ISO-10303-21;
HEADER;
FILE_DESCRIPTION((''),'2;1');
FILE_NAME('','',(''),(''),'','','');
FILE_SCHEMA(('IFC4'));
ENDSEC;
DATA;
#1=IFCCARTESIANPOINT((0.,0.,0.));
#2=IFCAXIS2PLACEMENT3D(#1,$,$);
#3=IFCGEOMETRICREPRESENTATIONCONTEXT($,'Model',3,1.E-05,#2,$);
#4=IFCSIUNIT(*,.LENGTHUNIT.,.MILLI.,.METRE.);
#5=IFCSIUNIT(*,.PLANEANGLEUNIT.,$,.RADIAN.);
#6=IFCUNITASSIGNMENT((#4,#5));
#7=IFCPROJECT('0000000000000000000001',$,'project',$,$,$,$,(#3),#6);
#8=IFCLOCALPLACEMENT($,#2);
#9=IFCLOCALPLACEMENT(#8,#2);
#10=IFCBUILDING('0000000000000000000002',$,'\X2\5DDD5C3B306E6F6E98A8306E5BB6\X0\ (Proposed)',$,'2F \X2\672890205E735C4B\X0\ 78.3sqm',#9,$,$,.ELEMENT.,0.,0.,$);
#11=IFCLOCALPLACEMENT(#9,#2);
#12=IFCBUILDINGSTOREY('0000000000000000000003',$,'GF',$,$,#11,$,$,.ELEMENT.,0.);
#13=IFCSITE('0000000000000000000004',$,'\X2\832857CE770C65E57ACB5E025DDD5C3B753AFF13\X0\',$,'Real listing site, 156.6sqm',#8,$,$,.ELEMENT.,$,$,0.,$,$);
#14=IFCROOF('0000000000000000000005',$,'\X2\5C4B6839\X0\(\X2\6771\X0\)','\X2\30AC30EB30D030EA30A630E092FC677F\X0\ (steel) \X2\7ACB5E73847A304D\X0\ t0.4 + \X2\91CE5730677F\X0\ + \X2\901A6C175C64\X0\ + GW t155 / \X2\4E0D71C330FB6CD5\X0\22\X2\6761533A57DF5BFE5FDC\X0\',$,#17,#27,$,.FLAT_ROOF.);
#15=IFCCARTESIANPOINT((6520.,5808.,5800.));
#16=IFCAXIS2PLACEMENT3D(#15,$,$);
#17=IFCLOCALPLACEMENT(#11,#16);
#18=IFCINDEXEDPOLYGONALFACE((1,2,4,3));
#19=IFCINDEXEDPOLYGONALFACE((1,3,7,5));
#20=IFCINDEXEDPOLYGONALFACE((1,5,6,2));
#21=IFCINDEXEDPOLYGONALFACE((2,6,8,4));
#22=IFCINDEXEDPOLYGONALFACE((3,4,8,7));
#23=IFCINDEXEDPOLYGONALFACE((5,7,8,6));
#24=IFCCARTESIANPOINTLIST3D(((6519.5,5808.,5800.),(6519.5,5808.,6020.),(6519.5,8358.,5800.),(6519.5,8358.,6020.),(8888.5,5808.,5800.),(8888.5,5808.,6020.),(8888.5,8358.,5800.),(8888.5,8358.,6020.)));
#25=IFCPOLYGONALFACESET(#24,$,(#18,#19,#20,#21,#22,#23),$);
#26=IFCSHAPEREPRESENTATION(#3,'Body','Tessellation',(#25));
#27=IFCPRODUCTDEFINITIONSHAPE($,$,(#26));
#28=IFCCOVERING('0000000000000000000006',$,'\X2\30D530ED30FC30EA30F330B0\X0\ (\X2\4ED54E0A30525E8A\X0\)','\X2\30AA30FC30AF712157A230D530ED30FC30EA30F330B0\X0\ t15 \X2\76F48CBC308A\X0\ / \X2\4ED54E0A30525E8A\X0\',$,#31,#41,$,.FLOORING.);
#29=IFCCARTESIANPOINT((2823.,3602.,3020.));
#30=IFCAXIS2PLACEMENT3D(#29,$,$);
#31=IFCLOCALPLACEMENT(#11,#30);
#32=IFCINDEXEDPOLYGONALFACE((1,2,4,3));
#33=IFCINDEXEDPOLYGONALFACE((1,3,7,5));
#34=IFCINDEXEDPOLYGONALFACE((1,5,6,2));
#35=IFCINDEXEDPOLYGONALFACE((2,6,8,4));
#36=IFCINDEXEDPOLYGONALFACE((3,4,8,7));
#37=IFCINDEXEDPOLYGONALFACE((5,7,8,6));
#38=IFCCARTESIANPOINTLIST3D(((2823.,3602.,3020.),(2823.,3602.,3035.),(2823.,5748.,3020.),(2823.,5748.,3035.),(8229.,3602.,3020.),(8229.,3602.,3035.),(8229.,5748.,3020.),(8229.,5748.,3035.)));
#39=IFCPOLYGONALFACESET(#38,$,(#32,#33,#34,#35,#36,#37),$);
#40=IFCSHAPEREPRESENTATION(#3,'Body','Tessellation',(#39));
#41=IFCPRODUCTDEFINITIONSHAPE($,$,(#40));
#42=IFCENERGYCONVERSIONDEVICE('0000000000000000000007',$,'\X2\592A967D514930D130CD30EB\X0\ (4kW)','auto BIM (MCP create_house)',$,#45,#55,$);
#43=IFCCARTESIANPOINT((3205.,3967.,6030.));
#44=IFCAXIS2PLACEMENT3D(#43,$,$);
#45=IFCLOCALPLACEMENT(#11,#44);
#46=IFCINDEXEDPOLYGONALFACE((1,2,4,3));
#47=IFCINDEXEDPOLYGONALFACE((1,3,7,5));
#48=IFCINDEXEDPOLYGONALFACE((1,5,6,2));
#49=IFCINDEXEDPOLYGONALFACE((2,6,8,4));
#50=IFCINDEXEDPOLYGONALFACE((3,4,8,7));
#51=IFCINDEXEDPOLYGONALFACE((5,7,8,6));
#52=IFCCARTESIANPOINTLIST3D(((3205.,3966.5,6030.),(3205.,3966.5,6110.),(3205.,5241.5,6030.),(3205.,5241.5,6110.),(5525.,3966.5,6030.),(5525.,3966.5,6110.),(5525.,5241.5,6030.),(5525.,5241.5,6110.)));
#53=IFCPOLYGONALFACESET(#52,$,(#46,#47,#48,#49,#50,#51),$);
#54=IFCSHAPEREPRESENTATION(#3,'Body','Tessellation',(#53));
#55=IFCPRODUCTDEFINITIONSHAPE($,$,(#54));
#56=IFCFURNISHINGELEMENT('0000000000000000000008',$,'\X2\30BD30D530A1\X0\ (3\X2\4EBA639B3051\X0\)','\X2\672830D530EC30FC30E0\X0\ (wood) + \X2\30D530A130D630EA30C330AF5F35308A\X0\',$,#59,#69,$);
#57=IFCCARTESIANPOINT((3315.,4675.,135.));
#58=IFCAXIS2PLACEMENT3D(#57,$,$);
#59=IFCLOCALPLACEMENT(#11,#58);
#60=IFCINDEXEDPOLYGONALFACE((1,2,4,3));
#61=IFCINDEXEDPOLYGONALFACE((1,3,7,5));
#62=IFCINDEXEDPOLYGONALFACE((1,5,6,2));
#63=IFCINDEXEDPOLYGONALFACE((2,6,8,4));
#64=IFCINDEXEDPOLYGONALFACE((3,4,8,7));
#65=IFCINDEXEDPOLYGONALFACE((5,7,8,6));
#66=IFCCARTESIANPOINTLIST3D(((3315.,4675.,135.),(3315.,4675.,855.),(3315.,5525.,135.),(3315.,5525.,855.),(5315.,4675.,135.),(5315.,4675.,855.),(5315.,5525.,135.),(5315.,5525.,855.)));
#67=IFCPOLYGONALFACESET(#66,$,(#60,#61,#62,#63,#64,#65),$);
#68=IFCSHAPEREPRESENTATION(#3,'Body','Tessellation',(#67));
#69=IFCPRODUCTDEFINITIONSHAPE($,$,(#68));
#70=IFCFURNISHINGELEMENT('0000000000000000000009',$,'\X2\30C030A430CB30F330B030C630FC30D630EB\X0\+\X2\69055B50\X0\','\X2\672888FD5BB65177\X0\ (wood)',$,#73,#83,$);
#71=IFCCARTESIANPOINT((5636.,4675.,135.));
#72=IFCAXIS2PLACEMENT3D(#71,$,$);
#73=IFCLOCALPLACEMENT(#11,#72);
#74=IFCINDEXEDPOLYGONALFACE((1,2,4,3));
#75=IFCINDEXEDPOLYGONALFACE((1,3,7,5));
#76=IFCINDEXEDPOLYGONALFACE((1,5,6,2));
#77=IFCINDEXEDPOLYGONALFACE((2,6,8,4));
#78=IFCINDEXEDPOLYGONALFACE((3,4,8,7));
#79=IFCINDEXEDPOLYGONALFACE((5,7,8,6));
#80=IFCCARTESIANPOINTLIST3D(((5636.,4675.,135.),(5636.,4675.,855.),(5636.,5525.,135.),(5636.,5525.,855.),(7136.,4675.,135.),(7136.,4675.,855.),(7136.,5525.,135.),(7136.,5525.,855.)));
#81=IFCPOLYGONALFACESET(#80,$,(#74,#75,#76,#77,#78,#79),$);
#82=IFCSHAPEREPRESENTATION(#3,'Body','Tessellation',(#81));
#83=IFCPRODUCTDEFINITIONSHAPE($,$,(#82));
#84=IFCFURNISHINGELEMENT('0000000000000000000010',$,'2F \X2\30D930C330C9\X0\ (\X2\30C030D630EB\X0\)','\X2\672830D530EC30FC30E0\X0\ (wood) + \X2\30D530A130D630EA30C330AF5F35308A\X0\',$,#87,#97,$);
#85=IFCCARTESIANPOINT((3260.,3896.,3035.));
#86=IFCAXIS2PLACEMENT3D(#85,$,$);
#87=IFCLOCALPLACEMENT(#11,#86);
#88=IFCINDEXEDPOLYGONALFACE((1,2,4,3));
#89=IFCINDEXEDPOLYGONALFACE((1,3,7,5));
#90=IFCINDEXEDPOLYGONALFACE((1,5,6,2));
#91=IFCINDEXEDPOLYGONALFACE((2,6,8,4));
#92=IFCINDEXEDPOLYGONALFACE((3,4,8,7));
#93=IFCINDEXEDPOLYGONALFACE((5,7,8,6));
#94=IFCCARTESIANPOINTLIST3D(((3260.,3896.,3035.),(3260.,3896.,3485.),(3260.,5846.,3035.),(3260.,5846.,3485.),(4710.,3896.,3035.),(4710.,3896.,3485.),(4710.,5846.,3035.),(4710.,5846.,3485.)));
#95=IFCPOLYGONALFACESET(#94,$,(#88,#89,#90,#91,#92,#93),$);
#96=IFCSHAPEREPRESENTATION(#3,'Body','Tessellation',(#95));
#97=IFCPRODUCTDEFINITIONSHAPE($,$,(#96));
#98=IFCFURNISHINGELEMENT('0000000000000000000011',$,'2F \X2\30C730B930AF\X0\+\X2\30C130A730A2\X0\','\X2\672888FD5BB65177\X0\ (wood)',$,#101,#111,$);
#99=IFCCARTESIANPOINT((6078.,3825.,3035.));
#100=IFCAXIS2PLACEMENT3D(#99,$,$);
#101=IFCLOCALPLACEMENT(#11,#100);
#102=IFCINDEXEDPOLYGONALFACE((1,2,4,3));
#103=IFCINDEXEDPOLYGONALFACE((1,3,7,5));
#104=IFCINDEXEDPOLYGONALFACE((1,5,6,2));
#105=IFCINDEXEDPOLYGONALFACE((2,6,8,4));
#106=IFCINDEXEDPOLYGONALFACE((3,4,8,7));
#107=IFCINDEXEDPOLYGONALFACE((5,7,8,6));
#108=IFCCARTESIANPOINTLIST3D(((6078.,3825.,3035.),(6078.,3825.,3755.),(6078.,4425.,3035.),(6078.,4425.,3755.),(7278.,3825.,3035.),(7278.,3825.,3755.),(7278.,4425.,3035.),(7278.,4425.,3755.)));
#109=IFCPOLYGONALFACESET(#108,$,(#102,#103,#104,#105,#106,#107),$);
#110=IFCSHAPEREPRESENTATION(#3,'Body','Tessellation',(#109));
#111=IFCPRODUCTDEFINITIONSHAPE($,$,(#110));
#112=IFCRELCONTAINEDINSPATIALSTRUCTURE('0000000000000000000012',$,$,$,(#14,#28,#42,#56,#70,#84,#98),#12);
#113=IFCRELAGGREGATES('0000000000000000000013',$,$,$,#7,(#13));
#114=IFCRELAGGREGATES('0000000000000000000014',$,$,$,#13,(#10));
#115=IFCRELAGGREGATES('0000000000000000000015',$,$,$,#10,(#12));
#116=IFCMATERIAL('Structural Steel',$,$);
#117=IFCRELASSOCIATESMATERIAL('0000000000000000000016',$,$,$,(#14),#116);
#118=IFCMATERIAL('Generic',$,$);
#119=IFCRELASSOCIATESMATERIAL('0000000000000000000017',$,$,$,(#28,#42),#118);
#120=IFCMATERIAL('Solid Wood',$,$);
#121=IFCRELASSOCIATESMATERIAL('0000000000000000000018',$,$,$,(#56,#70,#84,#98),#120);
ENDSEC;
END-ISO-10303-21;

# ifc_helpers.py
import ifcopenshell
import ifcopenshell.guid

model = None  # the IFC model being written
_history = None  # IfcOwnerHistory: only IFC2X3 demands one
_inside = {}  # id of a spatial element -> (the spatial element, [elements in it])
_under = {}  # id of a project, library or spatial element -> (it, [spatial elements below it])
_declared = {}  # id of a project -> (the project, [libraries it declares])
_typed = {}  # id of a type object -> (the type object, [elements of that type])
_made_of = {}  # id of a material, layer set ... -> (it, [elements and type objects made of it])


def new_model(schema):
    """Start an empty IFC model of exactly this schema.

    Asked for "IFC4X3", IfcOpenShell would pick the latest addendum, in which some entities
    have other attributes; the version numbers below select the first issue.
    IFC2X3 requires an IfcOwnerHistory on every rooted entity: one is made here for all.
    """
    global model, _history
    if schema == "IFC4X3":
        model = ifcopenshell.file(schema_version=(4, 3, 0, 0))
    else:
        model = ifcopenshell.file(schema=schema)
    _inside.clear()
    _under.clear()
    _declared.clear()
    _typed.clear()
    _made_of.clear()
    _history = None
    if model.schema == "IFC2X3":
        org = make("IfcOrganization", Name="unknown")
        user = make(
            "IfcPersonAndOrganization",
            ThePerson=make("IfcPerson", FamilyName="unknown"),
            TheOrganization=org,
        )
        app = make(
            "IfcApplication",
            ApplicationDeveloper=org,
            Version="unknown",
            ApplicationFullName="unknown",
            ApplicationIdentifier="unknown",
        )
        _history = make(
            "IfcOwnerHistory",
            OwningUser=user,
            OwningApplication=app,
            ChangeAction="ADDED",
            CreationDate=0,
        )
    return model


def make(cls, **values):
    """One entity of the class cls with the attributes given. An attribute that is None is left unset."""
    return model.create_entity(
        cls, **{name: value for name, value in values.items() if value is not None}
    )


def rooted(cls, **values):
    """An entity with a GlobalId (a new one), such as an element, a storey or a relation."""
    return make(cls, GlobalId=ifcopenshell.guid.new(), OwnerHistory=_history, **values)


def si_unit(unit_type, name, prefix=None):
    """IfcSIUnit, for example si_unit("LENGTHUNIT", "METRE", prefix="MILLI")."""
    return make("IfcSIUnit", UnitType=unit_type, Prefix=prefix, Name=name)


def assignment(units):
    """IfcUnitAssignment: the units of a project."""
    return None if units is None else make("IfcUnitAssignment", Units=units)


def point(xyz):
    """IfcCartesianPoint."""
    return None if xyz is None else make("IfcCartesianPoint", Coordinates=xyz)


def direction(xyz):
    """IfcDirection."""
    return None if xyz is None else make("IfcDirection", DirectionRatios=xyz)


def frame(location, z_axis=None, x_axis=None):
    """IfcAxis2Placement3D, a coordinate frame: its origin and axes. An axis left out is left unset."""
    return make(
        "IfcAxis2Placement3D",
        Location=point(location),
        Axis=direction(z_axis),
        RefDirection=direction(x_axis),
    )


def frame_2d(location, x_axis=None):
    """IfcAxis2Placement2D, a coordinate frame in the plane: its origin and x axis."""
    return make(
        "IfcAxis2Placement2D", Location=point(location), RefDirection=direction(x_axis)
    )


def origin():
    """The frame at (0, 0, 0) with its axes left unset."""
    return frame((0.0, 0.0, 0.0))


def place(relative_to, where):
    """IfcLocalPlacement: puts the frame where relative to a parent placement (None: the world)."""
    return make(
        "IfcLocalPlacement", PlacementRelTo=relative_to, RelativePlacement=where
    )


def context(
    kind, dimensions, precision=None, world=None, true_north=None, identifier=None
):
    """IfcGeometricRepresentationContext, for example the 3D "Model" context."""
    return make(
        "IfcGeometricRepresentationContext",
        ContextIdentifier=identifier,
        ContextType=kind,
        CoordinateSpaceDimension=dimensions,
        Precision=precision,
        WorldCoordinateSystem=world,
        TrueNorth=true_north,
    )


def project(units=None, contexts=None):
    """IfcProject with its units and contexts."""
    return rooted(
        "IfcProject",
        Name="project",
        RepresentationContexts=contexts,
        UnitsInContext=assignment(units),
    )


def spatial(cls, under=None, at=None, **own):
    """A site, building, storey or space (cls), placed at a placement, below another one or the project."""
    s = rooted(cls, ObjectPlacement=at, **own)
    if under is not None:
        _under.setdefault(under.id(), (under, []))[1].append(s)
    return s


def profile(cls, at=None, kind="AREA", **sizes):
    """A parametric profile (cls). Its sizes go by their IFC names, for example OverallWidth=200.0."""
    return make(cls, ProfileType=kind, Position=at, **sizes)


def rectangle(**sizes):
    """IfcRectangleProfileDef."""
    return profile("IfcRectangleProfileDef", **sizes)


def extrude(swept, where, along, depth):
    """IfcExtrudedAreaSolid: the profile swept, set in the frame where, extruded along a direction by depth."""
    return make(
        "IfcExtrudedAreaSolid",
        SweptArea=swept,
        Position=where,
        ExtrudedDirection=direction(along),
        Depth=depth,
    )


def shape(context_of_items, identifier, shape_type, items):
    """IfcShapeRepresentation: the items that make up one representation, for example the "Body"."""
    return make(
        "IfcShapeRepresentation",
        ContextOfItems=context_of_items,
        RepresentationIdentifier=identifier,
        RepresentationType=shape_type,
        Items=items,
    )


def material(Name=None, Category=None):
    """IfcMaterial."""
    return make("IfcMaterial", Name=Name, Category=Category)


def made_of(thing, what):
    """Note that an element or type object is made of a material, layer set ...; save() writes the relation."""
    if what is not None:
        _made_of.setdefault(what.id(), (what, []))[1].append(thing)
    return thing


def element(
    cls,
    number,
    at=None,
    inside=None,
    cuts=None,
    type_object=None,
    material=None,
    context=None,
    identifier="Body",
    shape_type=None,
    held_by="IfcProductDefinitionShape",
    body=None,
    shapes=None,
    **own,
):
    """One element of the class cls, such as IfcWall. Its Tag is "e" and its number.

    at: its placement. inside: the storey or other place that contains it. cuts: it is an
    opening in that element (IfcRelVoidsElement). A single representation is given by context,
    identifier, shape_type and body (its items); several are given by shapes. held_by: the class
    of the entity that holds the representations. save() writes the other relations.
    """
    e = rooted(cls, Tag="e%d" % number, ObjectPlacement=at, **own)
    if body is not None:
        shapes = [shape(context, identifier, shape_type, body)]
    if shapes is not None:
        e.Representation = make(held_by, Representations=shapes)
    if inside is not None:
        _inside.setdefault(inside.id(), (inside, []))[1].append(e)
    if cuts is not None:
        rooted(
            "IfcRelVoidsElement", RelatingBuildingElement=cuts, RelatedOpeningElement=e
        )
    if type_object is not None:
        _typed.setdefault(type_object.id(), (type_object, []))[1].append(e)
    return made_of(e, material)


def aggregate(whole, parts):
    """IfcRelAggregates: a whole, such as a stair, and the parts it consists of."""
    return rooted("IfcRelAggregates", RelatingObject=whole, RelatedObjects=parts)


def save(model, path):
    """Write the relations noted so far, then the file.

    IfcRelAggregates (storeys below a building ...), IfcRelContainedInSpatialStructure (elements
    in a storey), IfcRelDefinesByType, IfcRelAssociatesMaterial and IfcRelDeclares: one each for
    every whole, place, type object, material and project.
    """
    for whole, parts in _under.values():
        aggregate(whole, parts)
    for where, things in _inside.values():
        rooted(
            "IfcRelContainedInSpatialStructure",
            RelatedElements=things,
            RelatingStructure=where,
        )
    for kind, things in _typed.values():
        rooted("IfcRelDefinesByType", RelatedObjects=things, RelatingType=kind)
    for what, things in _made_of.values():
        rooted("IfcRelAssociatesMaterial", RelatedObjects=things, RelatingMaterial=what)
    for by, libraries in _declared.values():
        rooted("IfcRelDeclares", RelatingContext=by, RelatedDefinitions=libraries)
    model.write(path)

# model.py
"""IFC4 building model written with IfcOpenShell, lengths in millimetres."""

from ifc_helpers import new_model, si_unit, frame, frame_2d, origin, place, context, project, spatial, rectangle, extrude, material, element, save


model = new_model("IFC4")

# Units and contexts
model_context = context("Model", 3, precision=1e-05, world=origin())
ifc_project = project(units=[si_unit("LENGTHUNIT", "METRE", prefix="MILLI"), si_unit("PLANEANGLEUNIT", "RADIAN")], contexts=[model_context])

# Site, building, storey
site_placement = place(None, origin())
site = spatial("IfcSite", under=ifc_project, at=site_placement, Name="茨城県日立市川尻町３", ObjectType="Real listing site, 156.6sqm", CompositionType="ELEMENT", RefElevation=0.0)
building_placement = place(site_placement, origin())
building = spatial("IfcBuilding", under=site, at=building_placement, Name="川尻の潮風の家 (Proposed)", ObjectType="2F 木造平屋 78.3sqm", CompositionType="ELEMENT", ElevationOfRefHeight=0.0, ElevationOfTerrain=0.0)
storey_placement = place(building_placement, origin())
storey = spatial("IfcBuildingStorey", under=building, at=storey_placement, Name="GF", CompositionType="ELEMENT", Elevation=0.0)

# Shared definitions
ifc_material_1 = material(Name="Solid Wood")

# Roof
ifc_material_2 = material(Name="Structural Steel")
roof_1_placement = place(storey_placement, frame((6520.0, 5808.0, 5800.0)))
element("IfcRoof", 1, at=roof_1_placement, inside=storey, material=ifc_material_2, Name="屋根(東)", Description="ガルバリウム鋼板 (steel) 立平葺き t0.4 + 野地板 + 通気層 + GW t155 / 不燃・法22条区域対応", PredefinedType="FLAT_ROOF", context=model_context, shape_type="SweptSolid", body=[
    extrude(rectangle(XDim=2369.0, YDim=2550.0, at=frame_2d((1184.0, 1275.0))), frame((6520.0, 5808.0, 5800.0)), (0.0, 0.0, 1.0), 220.0),
])

# Covering
ifc_material_3 = material(Name="Generic")
covering_placement = place(storey_placement, frame((2823.0, 3602.0, 3020.0)))
element("IfcCovering", 2, at=covering_placement, inside=storey, material=ifc_material_3, Name="フローリング (仕上げ床)", Description="オーク無垢フローリング t15 直貼り / 仕上げ床", PredefinedType="FLOORING", context=model_context, shape_type="SweptSolid", body=[
    extrude(rectangle(XDim=5406.0, YDim=2146.0, at=frame_2d((2703.0, 1073.0))), frame((2823.0, 3602.0, 3020.0)), (0.0, 0.0, 1.0), 15.0),
])

# Energy conversion device
energy_conversion_device_placement = place(storey_placement, frame((3205.0, 3967.0, 6030.0)))
element("IfcEnergyConversionDevice", 3, at=energy_conversion_device_placement, inside=storey, material=ifc_material_3, Name="太陽光パネル (4kW)", Description="auto BIM (MCP create_house)", context=model_context, shape_type="SweptSolid", body=[
    extrude(rectangle(XDim=2320.0, YDim=1275.0, at=frame_2d((1160.0, 637.0))), frame((3205.0, 3967.0, 6030.0)), (0.0, 0.0, 1.0), 80.0),
])

# Furnishing elements
furnishing_1_placement = place(storey_placement, frame((3315.0, 4675.0, 135.0)))
element("IfcFurnishingElement", 4, at=furnishing_1_placement, inside=storey, material=ifc_material_1, Name="ソファ (3人掛け)", Description="木フレーム (wood) + ファブリック張り", context=model_context, shape_type="SweptSolid", body=[
    extrude(rectangle(XDim=2000.0, YDim=850.0, at=frame_2d((1000.0, 425.0))), frame((3315.0, 4675.0, 135.0)), (0.0, 0.0, 1.0), 720.0),
])
furnishing_2_placement = place(storey_placement, frame((5636.0, 4675.0, 135.0)))
element("IfcFurnishingElement", 5, at=furnishing_2_placement, inside=storey, material=ifc_material_1, Name="ダイニングテーブル+椅子", Description="木製家具 (wood)", context=model_context, shape_type="SweptSolid", body=[
    extrude(rectangle(XDim=1500.0, YDim=850.0, at=frame_2d((750.0, 425.0))), frame((5636.0, 4675.0, 135.0)), (0.0, 0.0, 1.0), 720.0),
])
furnishing_3_placement = place(storey_placement, frame((3260.0, 3896.0, 3035.0)))
element("IfcFurnishingElement", 6, at=furnishing_3_placement, inside=storey, material=ifc_material_1, Name="2F ベッド (ダブル)", Description="木フレーム (wood) + ファブリック張り", context=model_context, shape_type="SweptSolid", body=[
    extrude(rectangle(XDim=1450.0, YDim=1950.0, at=frame_2d((725.0, 975.0))), frame((3260.0, 3896.0, 3035.0)), (0.0, 0.0, 1.0), 450.0),
])
furnishing_4_placement = place(storey_placement, frame((6078.0, 3825.0, 3035.0)))
element("IfcFurnishingElement", 7, at=furnishing_4_placement, inside=storey, material=ifc_material_1, Name="2F デスク+チェア", Description="木製家具 (wood)", context=model_context, shape_type="SweptSolid", body=[
    extrude(rectangle(XDim=1200.0, YDim=600.0, at=frame_2d((600.0, 300.0))), frame((6078.0, 3825.0, 3035.0)), (0.0, 0.0, 1.0), 720.0),
])

save(model, "model.ifc")
